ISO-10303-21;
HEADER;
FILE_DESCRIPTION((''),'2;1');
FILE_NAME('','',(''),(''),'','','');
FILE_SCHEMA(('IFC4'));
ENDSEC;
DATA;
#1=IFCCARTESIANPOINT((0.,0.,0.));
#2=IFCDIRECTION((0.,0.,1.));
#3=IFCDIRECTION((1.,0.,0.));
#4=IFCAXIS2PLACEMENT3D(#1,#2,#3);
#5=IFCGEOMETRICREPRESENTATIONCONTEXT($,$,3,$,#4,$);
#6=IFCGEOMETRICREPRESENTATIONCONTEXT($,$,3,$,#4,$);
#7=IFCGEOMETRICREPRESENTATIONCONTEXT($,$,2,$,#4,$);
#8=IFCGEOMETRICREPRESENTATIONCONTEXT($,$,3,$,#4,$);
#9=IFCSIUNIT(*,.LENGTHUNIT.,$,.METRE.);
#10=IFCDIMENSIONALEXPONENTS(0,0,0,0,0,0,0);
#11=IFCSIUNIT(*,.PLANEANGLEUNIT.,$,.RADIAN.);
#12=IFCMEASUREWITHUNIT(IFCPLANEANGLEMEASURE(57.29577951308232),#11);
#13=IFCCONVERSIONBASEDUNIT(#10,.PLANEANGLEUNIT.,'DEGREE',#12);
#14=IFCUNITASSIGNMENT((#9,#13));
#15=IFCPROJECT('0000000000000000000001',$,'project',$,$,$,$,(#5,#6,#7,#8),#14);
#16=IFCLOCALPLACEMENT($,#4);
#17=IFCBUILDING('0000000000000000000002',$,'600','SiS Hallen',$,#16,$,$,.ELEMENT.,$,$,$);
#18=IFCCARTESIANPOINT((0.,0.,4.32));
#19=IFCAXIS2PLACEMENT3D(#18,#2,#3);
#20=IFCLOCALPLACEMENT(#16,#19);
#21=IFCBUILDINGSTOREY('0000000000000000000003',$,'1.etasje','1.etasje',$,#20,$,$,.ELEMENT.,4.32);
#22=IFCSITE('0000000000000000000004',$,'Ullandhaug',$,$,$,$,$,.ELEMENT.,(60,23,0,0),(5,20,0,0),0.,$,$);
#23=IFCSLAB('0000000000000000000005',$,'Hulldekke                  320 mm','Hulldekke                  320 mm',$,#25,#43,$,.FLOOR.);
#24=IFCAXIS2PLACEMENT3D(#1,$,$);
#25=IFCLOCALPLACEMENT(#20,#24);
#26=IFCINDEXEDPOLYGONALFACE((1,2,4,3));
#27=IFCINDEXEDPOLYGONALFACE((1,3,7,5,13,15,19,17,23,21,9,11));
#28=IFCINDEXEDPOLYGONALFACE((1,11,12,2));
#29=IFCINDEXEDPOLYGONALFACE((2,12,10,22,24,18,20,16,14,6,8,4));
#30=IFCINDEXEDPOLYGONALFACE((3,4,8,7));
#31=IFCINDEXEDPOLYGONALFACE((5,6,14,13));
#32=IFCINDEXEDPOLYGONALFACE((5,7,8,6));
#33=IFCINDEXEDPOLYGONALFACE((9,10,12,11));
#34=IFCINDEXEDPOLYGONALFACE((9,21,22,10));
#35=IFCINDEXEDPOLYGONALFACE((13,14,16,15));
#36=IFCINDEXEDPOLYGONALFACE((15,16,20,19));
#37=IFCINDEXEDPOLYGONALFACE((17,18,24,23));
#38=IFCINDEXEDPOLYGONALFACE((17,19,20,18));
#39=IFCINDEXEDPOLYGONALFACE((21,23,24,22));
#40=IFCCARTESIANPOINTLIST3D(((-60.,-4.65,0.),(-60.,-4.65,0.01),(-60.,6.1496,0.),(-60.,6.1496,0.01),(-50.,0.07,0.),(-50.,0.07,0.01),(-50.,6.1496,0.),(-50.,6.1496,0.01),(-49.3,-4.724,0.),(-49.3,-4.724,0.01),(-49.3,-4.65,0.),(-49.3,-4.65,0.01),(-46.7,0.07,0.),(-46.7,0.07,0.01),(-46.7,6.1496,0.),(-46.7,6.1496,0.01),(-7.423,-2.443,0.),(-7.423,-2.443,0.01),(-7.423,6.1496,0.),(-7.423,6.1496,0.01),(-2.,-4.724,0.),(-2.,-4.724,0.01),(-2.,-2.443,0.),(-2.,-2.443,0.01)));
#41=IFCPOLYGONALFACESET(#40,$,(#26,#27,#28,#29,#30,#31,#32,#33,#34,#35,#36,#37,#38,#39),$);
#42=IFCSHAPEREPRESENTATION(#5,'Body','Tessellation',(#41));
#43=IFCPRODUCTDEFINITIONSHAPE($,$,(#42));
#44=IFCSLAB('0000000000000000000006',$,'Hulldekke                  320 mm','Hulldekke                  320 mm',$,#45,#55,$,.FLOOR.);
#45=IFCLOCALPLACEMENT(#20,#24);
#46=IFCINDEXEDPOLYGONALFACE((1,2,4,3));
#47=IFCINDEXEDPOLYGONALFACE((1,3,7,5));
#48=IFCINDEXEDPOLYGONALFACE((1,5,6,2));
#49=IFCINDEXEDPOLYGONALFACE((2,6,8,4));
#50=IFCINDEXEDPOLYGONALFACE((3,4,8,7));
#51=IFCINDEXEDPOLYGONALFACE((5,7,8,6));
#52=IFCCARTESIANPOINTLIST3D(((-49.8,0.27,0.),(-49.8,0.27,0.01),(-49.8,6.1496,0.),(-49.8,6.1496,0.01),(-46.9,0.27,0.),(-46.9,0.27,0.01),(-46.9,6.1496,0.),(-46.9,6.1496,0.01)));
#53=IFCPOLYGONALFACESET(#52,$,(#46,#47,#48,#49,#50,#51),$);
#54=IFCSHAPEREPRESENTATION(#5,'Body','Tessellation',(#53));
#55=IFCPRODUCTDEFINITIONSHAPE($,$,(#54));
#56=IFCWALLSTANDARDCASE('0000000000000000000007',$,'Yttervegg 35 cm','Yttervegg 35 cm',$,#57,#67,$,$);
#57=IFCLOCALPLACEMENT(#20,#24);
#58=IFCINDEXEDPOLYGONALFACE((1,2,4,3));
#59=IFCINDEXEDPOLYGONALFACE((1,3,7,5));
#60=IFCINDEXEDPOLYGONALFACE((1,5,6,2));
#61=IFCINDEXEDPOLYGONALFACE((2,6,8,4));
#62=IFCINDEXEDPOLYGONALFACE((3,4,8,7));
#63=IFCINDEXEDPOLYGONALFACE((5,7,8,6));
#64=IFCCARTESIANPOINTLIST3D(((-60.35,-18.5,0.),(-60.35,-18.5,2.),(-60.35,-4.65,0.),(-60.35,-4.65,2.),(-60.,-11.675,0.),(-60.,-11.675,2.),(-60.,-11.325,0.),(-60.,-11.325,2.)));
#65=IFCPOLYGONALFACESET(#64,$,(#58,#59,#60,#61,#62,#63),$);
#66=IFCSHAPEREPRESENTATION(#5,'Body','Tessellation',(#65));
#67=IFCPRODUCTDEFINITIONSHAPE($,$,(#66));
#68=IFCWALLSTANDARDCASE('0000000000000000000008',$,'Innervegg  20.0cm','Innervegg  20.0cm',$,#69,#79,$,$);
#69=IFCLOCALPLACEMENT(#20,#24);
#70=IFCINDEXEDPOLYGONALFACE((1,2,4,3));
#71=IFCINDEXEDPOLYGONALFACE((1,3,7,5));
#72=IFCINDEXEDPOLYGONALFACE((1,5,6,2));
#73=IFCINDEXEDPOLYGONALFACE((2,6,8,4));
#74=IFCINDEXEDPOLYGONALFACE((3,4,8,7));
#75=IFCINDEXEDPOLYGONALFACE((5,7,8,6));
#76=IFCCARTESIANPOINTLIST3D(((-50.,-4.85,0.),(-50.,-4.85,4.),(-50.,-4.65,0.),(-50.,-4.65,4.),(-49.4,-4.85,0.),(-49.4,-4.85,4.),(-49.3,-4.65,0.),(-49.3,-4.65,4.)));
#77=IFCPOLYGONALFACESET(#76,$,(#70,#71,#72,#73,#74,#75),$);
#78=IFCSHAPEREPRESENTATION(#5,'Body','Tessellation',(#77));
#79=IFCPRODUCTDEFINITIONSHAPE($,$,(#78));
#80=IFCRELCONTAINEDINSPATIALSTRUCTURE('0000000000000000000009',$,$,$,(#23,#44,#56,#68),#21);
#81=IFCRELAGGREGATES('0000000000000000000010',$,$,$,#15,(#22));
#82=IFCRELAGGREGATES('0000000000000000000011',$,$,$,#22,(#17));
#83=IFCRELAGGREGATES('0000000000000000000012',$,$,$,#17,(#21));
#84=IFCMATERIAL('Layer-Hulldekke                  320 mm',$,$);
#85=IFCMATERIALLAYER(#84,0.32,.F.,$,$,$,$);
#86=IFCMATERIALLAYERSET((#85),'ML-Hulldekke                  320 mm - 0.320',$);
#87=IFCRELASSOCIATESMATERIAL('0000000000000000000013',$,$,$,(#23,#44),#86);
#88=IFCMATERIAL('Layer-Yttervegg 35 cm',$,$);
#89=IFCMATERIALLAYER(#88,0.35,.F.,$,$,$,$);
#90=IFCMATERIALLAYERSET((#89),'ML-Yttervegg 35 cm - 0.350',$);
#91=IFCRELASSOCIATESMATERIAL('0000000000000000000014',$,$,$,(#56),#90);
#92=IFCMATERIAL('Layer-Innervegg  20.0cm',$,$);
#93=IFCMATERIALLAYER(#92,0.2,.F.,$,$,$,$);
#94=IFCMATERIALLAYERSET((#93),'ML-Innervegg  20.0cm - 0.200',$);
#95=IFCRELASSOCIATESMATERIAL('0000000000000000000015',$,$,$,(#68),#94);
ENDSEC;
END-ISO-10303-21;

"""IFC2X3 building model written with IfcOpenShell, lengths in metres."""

from ifc_helpers import new_model, entity, si_unit, converted_unit, frame, origin_with_axes, place, context, project, spatial, polyline, outline, extrude, material, layer, layer_set, layer_usage, element, save


model = new_model("IFC2X3")

# Units and contexts
context_of_model_1 = context(None, 3, world=origin_with_axes())
context_of_model_2 = context(None, 3, world=origin_with_axes())
context_of_model_3 = context(None, 2, world=origin_with_axes())
context_of_model_4 = context(None, 3, world=origin_with_axes())
ifc_project = project(units=[si_unit("LENGTHUNIT", "METRE"), converted_unit("PLANEANGLEUNIT", "DEGREE", entity("IfcPlaneAngleMeasure", 57.29577951308232), si_unit("PLANEANGLEUNIT", "RADIAN"), dimensions=[0, 0, 0, 0, 0, 0, 0])], contexts=[context_of_model_1, context_of_model_2, context_of_model_3, context_of_model_4])

# Site, building, storey
site = spatial("IfcSite", under=ifc_project, Name="Ullandhaug", CompositionType="ELEMENT", RefLatitude=(60, 23, 0, 0), RefLongitude=(5, 20, 0, 0), RefElevation=0.0)
building_placement = place(None, origin_with_axes())
building = spatial("IfcBuilding", under=site, at=building_placement, Name="600", Description="SiS Hallen", CompositionType="ELEMENT")
storey_placement = place(building_placement, frame((0.0, 0.0, 4.32), z_axis=(0.0, 0.0, 1.0), x_axis=(1.0, 0.0, 0.0)))
storey = spatial("IfcBuildingStorey", under=building, at=storey_placement, Name="1.etasje", Description="1.etasje", CompositionType="ELEMENT", Elevation=4.32)

# Slabs
ifc_material_1 = material(Name="Layer-Hulldekke                  320 mm")
ifc_layer_1 = layer(ifc_material_1, 0.32, ventilated=False)
ifc_layer_set_1 = layer_set([ifc_layer_1], Name="ML-Hulldekke                  320 mm - 0.320")
ifc_layer_usage_1 = layer_usage(ifc_layer_set_1, "AXIS2", "POSITIVE", 0.0)
slab_1_placement = place(storey_placement, frame((-60.0, -4.65, 0.0), z_axis=(0.0, 0.0, 1.0), x_axis=(1.0, 0.0, 0.0)))
element("IfcSlab", 1, at=slab_1_placement, inside=storey, material=ifc_layer_usage_1, Name="Hulldekke                  320 mm", Description="Hulldekke                  320 mm", PredefinedType="FLOOR", context=context_of_model_1, shape_type="SweptSolid", body=[
    extrude(outline(polyline([(0.0, 0.0), (10.7, 0.0), (10.7, 0.074), (58.0, 0.074), (58.0, -2.207), (52.577, -2.207), (52.577, -10.7996), (13.3, -10.7996), (13.3, -4.72), (10.0, -4.72), (10.0, -10.7996), (0.0, -10.7996), (0.0, 0.0)])), frame((0.0, 0.0, 0.0), z_axis=(0.0, 0.0, -1.0), x_axis=(1.0, 0.0, 0.0)), (0.0, 0.0, -1.0), 0.01),
])
slab_2_placement = place(storey_placement, frame((-49.8, 0.27, 0.0), z_axis=(0.0, 0.0, 1.0), x_axis=(1.0, 0.0, 0.0)))
element("IfcSlab", 2, at=slab_2_placement, inside=storey, material=ifc_layer_usage_1, Name="Hulldekke                  320 mm", Description="Hulldekke                  320 mm", PredefinedType="FLOOR", context=context_of_model_1, shape_type="SweptSolid", body=[
    extrude(outline(polyline([(0.0, 0.0), (2.9, 0.0), (2.9, 5.8796), (0.0, 5.8796), (0.0, 0.0)])), origin_with_axes(), (0.0, 0.0, 1.0), 0.01),
])

# Walls
ifc_material_2 = material(Name="Layer-Yttervegg 35 cm")
ifc_layer_2 = layer(ifc_material_2, 0.35, ventilated=False)
ifc_layer_set_2 = layer_set([ifc_layer_2], Name="ML-Yttervegg 35 cm - 0.350")
ifc_layer_usage_2 = layer_usage(ifc_layer_set_2, "AXIS2", "POSITIVE", 0.0)
wall_1_placement = place(storey_placement, frame((-60.35, -4.65, 0.0), z_axis=(0.0, 0.0, 1.0), x_axis=(0.0, -1.0, 0.0)))
element("IfcWallStandardCase", 3, at=wall_1_placement, inside=storey, material=ifc_layer_usage_2, Name="Yttervegg 35 cm", Description="Yttervegg 35 cm", context=context_of_model_1, shape_type="SweptSolid", body=[
    extrude(outline(polyline([(0.0, 0.0), (13.85, 0.0), (7.025, 0.35), (6.675, 0.35), (0.0, 0.0)])), frame((0.0, 0.0, 0.0), z_axis=(0.0, 0.0, 1.0), x_axis=(1.0, 0.0, 0.0)), (0.0, 0.0, 1.0), 2.0),
])
ifc_material_3 = material(Name="Layer-Innervegg  20.0cm")
ifc_layer_3 = layer(ifc_material_3, 0.2, ventilated=False)
ifc_layer_set_3 = layer_set([ifc_layer_3], Name="ML-Innervegg  20.0cm - 0.200")
ifc_layer_usage_3 = layer_usage(ifc_layer_set_3, "AXIS2", "POSITIVE", 0.0)
wall_2_placement = place(storey_placement, frame((-50.0, -4.85, 0.0), z_axis=(0.0, 0.0, 1.0), x_axis=(1.0, 0.0, 0.0)))
element("IfcWallStandardCase", 4, at=wall_2_placement, inside=storey, material=ifc_layer_usage_3, Name="Innervegg  20.0cm", Description="Innervegg  20.0cm", context=context_of_model_1, shape_type="SweptSolid", body=[
    extrude(outline(polyline([(0.0, 0.0), (0.6, 0.0), (0.7, 0.2), (0.0, 0.2), (0.0, 0.0)])), origin_with_axes(), (0.0, 0.0, 1.0), 4.0),
])

save(model, "model.ifc")
